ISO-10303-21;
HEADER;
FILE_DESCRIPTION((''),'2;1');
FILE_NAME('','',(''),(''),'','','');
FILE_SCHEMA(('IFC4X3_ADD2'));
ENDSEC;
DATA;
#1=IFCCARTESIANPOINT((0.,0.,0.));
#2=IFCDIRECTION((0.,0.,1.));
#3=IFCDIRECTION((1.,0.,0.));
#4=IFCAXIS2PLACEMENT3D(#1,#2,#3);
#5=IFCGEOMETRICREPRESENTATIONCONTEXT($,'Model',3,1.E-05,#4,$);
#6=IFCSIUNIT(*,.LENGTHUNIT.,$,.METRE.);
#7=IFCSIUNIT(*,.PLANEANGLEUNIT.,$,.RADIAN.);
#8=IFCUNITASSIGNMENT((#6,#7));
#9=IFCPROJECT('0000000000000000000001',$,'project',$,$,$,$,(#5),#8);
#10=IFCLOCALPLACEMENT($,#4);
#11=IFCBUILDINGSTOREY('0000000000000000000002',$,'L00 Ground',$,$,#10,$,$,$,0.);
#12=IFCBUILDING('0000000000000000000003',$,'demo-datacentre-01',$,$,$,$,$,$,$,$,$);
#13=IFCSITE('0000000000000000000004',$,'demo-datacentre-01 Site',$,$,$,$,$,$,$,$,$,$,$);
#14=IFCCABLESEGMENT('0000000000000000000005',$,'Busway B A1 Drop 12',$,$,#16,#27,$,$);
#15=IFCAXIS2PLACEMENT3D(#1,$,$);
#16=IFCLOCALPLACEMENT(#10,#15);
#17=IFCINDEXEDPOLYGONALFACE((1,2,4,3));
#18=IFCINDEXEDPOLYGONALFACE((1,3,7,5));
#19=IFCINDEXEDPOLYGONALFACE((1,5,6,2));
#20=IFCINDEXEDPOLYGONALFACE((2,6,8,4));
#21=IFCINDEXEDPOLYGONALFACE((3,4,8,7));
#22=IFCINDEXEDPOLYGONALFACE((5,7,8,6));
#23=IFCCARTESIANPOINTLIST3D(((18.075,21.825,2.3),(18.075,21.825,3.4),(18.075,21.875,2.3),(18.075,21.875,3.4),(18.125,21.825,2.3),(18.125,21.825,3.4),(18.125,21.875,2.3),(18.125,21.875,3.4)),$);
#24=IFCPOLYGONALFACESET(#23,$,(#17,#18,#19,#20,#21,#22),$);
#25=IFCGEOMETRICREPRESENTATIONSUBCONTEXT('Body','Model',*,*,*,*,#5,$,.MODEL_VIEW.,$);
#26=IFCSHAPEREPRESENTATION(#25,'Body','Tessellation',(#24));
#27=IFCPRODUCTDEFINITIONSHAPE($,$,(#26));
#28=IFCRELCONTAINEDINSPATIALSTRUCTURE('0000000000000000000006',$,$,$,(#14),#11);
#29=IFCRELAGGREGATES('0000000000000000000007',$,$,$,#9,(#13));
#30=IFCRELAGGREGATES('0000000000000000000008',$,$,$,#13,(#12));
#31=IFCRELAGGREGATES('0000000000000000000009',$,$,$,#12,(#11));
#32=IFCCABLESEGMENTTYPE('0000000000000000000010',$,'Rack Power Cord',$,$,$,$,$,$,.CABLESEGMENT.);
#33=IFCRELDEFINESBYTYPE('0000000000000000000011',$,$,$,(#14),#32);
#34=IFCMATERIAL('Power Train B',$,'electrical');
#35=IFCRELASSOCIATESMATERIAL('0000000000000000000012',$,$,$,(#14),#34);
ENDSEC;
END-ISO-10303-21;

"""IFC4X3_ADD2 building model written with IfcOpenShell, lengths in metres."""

from ifc_helpers import new_model, si_unit, frame, origin_with_axes, place, context, subcontext, project, spatial, rectangle, extrude, material, type_object, element, save


model = new_model("IFC4X3_ADD2")

# Units and contexts
model_context = context("Model", 3, precision=1e-05, world=origin_with_axes())
body_context = subcontext(model_context, "Body", "Model", "MODEL_VIEW")
ifc_project = project(units=[si_unit("LENGTHUNIT", "METRE"), si_unit("PLANEANGLEUNIT", "RADIAN")], contexts=[model_context])

# Site, building, storey
site = spatial("IfcSite", under=ifc_project, Name="demo-datacentre-01 Site")
building = spatial("IfcBuilding", under=site, Name="demo-datacentre-01")
storey_placement = place(None, origin_with_axes())
storey = spatial("IfcBuildingStorey", under=building, at=storey_placement, Name="L00 Ground", Elevation=0.0)

# Shared definitions
ifc_material_1 = material(Name="Power Train B", Category="electrical")

# Cable segment
cable_segment_type_1 = type_object("IfcCableSegmentType", Name="Rack Power Cord", PredefinedType="CABLESEGMENT")
for number, where, z_axis, x_axis, name in (
    (1, (18.1, 21.85, 3.4), (0.0, 0.0, -1.0), (1.0, 0.0, 0.0), "Busway B A1 Drop 12"),
):
    element("IfcCableSegment", number, at=place(storey_placement, frame(where, z_axis=z_axis, x_axis=x_axis)), inside=storey, type_object=cable_segment_type_1, material=ifc_material_1, Name=name, context=body_context, shape_type="SweptSolid", body=[
        extrude(rectangle(XDim=0.05, YDim=0.05), origin_with_axes(), (0.0, 0.0, 1.0), 1.1),
    ])

save(model, "model.ifc")
